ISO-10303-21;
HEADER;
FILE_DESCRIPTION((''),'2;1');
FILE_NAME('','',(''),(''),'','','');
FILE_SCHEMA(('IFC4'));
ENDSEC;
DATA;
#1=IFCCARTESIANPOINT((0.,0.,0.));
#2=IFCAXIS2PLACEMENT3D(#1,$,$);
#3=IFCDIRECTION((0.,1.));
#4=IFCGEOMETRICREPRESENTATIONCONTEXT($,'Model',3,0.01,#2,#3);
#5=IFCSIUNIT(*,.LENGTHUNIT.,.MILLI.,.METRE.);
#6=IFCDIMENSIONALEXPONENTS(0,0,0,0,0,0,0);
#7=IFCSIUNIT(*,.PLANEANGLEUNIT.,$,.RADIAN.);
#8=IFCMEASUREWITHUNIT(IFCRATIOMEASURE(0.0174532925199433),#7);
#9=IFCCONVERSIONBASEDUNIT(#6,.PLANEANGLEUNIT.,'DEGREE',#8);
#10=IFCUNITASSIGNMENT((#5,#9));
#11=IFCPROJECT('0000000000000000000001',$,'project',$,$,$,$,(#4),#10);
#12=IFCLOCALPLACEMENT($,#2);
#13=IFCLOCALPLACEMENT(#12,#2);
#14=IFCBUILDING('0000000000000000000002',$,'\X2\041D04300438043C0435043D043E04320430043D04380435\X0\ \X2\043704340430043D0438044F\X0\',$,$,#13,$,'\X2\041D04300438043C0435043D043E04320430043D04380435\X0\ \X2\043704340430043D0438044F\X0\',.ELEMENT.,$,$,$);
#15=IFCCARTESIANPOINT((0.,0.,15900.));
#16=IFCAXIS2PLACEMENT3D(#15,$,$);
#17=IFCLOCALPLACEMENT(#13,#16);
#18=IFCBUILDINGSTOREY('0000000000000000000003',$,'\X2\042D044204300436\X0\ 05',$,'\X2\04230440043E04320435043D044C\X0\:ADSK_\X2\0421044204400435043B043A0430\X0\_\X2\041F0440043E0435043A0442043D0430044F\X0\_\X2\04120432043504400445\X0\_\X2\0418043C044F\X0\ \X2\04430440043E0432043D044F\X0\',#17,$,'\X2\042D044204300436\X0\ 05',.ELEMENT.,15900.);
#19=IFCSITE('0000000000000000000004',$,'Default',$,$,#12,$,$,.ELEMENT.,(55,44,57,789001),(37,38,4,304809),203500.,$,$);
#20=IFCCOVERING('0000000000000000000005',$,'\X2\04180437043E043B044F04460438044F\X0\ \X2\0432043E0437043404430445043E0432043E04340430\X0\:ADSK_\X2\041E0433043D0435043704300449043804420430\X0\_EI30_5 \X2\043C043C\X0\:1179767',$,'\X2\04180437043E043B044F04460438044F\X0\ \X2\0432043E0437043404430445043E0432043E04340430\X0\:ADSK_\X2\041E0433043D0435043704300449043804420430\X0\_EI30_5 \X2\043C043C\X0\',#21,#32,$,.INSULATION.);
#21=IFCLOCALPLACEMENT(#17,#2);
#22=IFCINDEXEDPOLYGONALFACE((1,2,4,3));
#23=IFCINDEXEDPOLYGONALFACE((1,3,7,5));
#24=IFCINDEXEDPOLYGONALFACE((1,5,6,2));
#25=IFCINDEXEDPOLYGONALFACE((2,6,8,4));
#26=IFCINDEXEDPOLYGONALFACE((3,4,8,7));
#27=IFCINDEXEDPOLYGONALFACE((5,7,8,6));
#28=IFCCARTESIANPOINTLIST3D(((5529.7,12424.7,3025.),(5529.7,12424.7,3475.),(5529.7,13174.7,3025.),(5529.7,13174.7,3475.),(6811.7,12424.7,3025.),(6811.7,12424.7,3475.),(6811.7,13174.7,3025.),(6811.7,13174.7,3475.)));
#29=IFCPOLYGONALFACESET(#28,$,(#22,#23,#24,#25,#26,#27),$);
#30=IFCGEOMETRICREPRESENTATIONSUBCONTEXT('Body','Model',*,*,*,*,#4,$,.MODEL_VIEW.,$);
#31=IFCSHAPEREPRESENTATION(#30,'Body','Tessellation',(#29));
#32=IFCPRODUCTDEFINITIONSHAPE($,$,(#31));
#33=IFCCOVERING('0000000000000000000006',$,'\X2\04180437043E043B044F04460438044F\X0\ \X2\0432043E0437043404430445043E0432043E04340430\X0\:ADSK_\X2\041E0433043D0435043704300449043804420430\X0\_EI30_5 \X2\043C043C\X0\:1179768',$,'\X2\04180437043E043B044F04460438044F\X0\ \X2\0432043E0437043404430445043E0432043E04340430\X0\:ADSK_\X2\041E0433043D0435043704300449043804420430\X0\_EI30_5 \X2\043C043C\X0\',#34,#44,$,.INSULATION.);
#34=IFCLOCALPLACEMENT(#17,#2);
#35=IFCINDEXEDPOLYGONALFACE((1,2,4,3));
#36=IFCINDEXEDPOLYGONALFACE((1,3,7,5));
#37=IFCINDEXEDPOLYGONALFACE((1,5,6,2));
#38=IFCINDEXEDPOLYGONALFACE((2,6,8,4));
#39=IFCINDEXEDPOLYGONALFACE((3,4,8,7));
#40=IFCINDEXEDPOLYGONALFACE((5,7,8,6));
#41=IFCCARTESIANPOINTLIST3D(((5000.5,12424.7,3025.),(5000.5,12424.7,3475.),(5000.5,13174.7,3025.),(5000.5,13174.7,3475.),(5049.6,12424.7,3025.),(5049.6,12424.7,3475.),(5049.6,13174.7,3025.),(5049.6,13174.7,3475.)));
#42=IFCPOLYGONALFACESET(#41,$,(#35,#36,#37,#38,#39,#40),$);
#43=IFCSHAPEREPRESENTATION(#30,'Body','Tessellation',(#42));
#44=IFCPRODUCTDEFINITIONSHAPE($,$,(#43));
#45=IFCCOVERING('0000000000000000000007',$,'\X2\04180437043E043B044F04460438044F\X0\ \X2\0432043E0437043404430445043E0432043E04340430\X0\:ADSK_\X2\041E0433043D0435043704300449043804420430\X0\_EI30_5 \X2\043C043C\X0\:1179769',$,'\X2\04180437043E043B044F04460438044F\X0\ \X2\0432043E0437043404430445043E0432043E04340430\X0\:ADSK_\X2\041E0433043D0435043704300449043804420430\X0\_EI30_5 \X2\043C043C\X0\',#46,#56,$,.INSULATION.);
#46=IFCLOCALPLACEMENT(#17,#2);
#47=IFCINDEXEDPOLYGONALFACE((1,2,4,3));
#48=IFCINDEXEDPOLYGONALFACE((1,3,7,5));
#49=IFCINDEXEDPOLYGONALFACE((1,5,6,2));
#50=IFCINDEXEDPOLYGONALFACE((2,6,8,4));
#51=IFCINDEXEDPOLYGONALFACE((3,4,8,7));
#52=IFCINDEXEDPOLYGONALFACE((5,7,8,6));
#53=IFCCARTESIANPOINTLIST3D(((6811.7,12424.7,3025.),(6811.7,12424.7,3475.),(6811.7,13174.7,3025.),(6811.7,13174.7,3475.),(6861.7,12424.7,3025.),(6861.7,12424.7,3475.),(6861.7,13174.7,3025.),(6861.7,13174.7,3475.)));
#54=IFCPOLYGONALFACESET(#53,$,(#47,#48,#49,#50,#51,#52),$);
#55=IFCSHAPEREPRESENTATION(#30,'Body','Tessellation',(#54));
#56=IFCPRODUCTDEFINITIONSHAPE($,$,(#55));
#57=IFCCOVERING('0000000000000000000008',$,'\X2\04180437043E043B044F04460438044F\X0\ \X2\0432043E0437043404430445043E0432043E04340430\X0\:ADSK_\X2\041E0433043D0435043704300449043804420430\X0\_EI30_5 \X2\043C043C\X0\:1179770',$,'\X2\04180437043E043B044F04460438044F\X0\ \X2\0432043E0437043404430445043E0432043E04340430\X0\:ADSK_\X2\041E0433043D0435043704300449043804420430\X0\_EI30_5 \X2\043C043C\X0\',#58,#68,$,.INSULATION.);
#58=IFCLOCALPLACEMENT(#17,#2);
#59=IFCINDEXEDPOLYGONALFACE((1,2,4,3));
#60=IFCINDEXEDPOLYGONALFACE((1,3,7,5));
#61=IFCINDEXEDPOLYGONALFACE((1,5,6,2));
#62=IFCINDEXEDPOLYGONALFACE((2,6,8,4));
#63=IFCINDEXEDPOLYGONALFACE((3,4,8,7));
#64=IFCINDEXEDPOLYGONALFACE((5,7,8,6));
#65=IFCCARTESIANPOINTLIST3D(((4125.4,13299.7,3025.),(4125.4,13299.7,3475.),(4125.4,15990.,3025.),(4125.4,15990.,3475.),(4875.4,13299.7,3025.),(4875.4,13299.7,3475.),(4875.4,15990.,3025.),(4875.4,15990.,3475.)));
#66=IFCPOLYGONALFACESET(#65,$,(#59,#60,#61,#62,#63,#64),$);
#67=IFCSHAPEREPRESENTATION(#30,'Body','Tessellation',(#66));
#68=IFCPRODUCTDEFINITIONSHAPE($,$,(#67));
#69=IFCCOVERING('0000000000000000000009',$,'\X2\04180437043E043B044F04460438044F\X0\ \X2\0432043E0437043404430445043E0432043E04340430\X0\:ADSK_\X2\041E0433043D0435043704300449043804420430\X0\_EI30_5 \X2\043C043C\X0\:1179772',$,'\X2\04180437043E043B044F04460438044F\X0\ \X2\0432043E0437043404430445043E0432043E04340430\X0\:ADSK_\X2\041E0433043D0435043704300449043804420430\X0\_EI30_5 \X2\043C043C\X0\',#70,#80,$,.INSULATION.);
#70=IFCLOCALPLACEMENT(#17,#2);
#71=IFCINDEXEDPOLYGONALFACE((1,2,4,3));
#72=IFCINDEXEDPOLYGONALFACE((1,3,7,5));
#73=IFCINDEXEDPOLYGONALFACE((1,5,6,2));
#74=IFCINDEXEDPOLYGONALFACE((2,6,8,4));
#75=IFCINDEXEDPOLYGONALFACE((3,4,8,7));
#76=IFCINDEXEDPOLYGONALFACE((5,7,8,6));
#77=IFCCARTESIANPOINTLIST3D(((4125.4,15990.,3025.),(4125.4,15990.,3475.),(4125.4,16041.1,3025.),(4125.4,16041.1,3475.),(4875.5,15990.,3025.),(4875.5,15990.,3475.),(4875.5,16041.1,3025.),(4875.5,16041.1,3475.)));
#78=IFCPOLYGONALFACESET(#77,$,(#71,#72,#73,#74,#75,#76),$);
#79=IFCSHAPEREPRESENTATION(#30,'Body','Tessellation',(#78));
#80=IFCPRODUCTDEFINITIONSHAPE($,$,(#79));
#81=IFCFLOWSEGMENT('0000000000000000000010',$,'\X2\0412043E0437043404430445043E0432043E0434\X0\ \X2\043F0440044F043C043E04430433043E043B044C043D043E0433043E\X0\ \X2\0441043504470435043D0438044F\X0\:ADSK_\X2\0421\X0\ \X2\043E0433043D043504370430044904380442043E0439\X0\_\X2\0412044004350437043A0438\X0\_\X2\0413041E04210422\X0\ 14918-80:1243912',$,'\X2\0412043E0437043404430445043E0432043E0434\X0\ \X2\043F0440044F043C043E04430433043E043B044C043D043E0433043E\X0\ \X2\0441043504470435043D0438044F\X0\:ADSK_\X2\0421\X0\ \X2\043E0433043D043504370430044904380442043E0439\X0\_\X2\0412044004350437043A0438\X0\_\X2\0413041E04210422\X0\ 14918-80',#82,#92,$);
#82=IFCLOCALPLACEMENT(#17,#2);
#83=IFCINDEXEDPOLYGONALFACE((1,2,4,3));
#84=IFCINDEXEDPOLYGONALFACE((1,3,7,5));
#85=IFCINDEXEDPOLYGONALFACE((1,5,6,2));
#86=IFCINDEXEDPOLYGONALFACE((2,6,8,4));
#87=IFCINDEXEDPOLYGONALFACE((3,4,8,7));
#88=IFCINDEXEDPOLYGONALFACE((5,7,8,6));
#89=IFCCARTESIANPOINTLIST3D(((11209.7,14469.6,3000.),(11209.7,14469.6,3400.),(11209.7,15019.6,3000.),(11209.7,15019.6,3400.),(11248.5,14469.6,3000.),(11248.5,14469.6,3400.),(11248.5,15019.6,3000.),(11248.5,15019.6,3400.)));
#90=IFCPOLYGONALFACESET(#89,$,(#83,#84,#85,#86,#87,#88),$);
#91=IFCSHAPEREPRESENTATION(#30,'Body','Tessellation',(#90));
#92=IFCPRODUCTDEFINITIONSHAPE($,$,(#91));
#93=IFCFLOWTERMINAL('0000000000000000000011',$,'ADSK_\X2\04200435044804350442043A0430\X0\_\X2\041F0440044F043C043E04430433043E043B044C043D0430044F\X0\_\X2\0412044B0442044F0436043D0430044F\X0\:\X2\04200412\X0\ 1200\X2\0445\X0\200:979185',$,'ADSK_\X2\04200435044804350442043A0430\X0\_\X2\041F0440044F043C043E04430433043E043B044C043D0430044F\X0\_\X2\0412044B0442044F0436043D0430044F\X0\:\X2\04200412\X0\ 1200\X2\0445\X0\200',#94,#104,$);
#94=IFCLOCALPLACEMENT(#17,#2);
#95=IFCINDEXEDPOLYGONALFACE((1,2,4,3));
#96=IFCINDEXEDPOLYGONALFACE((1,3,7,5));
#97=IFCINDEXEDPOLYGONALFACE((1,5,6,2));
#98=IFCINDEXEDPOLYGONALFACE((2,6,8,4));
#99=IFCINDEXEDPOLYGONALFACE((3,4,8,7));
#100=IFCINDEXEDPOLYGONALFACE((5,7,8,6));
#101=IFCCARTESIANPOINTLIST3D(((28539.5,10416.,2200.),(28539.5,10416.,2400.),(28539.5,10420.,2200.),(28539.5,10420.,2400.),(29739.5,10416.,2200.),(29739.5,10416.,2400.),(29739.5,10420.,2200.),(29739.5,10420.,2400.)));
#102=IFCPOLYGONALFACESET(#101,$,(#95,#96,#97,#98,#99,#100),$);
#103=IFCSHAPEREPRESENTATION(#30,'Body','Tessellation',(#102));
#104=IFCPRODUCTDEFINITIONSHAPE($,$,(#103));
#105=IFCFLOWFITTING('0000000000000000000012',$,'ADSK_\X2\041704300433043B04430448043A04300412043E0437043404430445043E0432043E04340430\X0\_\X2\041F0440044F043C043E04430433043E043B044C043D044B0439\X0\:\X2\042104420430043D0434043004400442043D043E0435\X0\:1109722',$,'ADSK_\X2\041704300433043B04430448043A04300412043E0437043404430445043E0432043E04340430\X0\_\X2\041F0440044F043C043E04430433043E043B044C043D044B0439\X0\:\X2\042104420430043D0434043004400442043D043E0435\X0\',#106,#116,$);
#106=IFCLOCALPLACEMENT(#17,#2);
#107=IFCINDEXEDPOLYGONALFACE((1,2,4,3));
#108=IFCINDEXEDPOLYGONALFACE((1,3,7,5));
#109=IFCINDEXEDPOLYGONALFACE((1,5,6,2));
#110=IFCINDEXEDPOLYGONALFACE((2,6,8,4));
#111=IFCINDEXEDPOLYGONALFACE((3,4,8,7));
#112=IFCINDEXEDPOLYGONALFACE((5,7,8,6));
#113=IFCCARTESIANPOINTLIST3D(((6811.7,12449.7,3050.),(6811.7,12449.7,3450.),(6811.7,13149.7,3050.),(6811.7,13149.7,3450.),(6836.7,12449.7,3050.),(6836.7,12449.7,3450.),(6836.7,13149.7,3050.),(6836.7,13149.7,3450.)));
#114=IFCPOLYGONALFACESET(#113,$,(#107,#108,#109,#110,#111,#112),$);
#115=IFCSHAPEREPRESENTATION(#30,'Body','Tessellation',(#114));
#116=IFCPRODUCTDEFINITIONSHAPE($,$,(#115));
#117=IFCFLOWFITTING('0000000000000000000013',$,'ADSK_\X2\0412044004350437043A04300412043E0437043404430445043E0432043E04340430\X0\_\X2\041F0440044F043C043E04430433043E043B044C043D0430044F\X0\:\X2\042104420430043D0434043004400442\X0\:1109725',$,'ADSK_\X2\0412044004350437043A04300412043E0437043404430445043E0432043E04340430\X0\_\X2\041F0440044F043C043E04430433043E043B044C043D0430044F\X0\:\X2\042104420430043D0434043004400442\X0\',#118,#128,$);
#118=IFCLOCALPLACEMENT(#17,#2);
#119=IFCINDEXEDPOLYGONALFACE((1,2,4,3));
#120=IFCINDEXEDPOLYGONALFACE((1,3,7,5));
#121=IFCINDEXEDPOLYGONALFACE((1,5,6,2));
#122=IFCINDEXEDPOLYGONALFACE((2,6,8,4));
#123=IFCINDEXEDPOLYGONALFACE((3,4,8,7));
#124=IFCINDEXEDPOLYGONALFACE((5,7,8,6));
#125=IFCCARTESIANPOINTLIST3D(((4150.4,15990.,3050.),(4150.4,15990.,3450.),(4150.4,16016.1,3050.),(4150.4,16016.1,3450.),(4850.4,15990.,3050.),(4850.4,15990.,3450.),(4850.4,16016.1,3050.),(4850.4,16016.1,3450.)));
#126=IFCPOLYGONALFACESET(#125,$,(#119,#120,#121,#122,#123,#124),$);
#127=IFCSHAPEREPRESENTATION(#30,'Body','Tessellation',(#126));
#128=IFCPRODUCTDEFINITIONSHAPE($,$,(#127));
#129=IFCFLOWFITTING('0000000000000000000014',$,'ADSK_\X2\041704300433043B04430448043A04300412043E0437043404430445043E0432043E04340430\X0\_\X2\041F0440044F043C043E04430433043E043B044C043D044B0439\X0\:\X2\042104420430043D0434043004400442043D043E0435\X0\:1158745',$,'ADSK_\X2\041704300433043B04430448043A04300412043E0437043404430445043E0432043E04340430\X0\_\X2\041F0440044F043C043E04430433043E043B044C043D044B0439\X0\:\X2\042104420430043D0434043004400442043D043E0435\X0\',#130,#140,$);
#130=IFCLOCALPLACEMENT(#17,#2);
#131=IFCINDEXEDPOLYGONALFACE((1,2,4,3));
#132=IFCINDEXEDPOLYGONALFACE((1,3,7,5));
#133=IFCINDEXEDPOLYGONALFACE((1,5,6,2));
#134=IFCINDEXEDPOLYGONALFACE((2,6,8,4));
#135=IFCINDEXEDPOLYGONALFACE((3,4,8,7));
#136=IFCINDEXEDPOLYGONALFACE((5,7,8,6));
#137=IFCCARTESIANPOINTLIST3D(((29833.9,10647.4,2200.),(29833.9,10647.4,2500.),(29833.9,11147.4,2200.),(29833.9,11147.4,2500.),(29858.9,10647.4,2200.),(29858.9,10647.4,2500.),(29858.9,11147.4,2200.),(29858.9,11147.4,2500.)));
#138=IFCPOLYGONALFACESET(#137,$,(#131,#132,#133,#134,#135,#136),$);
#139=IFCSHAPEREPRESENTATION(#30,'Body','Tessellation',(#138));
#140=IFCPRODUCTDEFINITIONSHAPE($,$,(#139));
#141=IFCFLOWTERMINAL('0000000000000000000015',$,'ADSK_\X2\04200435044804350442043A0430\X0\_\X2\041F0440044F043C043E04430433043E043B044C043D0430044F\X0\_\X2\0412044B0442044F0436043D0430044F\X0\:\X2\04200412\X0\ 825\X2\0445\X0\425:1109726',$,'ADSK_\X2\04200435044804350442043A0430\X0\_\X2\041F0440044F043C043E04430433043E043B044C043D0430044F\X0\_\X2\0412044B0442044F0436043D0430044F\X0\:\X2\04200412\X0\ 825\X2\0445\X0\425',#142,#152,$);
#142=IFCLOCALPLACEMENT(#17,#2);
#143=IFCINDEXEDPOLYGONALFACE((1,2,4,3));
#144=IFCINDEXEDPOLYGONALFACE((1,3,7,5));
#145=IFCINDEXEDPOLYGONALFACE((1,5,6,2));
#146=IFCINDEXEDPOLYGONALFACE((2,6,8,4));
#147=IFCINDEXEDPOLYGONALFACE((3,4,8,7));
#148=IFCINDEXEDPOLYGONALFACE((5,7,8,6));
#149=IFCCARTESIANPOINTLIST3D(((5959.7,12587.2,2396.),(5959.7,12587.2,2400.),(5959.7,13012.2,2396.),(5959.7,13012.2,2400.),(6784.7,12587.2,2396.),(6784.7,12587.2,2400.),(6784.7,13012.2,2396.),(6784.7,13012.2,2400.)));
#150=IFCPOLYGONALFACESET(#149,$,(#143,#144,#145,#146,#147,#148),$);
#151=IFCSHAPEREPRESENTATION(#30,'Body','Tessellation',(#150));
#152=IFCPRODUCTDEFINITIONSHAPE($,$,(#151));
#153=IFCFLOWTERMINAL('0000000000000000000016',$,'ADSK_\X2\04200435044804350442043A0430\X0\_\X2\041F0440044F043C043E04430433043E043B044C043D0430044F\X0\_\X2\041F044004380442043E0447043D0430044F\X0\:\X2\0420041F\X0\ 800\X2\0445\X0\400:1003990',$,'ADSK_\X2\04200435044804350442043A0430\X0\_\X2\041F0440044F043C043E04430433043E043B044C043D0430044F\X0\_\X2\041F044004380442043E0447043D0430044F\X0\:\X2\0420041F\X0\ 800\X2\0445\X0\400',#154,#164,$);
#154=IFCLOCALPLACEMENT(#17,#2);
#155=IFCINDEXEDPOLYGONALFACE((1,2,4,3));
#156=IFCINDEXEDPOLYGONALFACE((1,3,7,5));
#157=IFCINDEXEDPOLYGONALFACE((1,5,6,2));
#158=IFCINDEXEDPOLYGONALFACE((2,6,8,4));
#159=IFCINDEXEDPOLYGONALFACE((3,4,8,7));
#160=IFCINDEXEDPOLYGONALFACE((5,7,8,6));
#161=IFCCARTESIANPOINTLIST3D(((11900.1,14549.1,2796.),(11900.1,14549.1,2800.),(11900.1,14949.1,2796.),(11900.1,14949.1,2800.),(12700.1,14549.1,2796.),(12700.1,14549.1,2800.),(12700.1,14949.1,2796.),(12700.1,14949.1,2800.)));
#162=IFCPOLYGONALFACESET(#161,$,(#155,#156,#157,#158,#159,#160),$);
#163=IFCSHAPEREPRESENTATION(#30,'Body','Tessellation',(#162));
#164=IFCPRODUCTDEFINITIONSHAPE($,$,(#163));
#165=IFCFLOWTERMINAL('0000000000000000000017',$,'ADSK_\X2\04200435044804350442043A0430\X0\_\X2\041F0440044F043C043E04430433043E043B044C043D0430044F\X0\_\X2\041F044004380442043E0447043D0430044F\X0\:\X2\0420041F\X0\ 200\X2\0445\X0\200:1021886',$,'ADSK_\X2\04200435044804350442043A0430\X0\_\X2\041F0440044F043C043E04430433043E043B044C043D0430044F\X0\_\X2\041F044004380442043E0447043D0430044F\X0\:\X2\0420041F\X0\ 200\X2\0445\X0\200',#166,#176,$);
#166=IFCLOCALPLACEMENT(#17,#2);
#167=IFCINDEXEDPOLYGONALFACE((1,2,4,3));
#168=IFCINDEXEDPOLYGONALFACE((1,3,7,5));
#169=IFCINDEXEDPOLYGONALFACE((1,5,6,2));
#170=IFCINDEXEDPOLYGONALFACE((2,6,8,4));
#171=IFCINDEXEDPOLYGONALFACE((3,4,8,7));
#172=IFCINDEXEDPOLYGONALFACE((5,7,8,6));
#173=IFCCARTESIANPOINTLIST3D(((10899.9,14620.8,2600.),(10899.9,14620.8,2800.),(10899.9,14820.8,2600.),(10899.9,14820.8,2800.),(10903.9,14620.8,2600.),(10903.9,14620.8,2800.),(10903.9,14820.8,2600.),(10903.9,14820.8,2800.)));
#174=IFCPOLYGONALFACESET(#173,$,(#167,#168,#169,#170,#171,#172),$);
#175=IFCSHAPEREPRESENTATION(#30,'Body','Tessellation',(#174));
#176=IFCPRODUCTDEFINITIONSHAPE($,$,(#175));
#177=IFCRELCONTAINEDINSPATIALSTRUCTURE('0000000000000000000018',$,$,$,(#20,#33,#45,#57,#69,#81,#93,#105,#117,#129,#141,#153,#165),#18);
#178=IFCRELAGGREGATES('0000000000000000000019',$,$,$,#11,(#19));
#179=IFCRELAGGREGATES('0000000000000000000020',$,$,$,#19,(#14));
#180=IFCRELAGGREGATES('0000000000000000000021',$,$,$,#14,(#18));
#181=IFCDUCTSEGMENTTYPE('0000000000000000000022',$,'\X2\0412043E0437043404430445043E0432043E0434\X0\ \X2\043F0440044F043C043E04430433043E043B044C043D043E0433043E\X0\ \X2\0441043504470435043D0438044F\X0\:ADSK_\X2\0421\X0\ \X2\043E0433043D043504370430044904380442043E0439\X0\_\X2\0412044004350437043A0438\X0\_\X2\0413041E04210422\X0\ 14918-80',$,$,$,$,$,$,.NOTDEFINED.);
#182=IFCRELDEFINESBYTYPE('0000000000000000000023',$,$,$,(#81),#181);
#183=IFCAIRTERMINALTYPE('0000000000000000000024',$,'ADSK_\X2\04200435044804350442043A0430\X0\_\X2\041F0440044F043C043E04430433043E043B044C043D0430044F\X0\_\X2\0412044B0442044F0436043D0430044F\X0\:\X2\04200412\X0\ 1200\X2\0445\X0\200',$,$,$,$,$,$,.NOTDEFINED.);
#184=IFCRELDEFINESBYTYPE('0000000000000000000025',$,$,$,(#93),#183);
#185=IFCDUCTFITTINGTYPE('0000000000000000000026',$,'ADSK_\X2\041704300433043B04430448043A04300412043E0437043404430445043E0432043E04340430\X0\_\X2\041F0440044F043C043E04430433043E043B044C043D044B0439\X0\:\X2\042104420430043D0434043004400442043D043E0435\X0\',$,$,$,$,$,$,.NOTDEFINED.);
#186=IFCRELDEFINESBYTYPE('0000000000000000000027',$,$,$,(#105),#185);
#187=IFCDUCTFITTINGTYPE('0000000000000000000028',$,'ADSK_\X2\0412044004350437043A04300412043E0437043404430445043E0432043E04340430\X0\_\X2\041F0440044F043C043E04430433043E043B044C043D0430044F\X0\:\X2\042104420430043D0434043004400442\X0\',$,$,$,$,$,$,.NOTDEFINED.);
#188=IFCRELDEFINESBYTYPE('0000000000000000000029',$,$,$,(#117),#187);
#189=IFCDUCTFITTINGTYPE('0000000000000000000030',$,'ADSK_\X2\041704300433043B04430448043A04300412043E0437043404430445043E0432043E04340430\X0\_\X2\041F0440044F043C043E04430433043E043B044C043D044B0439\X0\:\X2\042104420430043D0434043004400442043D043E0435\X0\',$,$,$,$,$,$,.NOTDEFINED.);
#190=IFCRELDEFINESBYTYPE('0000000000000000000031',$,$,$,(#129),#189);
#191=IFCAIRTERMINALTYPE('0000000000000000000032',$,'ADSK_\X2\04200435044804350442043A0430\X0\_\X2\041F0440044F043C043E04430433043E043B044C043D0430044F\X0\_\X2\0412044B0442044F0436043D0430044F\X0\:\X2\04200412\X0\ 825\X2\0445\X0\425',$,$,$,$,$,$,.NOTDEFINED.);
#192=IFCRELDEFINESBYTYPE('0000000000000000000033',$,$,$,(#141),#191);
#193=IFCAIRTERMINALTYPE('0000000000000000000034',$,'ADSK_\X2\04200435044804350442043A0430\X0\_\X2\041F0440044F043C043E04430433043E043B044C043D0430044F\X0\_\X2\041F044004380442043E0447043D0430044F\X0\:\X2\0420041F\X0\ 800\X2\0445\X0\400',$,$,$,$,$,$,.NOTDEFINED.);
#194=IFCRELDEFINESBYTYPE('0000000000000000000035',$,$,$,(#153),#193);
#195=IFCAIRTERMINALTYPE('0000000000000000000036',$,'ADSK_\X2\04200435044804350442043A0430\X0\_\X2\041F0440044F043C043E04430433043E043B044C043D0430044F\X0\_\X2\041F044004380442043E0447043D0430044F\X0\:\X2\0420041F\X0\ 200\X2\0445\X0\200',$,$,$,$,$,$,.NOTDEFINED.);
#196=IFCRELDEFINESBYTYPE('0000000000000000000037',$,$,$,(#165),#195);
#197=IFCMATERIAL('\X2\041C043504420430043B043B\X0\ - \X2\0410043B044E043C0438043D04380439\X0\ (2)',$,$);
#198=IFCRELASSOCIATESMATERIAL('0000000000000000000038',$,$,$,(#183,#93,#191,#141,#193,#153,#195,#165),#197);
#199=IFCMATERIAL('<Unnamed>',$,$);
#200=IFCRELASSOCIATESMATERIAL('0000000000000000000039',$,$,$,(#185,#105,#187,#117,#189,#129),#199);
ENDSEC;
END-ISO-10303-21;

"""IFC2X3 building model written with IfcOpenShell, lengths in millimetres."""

from ifc_helpers import new_model, entity, si_unit, converted_unit, direction, frame, origin, origin_2d_with_axis, place, context, subcontext, project, spatial, rectangle, extrude, source, transform, mapped, material, type_object, type_shapes, element, save


model = new_model("IFC2X3")

# Units and contexts
model_context = context("Model", 3, precision=0.01, world=origin(), true_north=direction((0.0, 1.0)))
body_context = subcontext(model_context, "Body", "Model", "MODEL_VIEW")
ifc_project = project(units=[si_unit("LENGTHUNIT", "METRE", prefix="MILLI"), converted_unit("PLANEANGLEUNIT", "DEGREE", entity("IfcRatioMeasure", 0.0174532925199433), si_unit("PLANEANGLEUNIT", "RADIAN"), dimensions=[0, 0, 0, 0, 0, 0, 0])], contexts=[model_context])

# Site, building, storey
site_placement = place(None, origin())
site = spatial("IfcSite", under=ifc_project, at=site_placement, Name="Default", CompositionType="ELEMENT", RefLatitude=(55, 44, 57, 789001), RefLongitude=(37, 38, 4, 304809), RefElevation=203500.0)
building_placement = place(site_placement, origin())
building = spatial("IfcBuilding", under=site, at=building_placement, Name="Наименование здания", LongName="Наименование здания", CompositionType="ELEMENT")
storey_placement = place(building_placement, frame((0.0, 0.0, 15900.0)))
storey = spatial("IfcBuildingStorey", under=building, at=storey_placement, Name="Этаж 05", ObjectType="Уровень:ADSK_Стрелка_Проектная_Вверх_Имя уровня", LongName="Этаж 05", CompositionType="ELEMENT", Elevation=15900.0)

# Coverings
covering_1_placement = place(storey_placement, frame((5529.6, 12424.7, 3025.0)))
element("IfcCovering", 1, at=covering_1_placement, inside=storey, Name="Изоляция воздуховода:ADSK_Огнезащита_EI30_5 мм:1179767", ObjectType="Изоляция воздуховода:ADSK_Огнезащита_EI30_5 мм", PredefinedType="INSULATION", context=body_context, shape_type="SweptSolid", body=[
    extrude(rectangle(XDim=1282.1, YDim=750.0, at=origin_2d_with_axis()), frame((641.0, 375.0, 0.0)), (0.0, 0.0, 1.0), 450.0),
])
covering_2_placement = place(storey_placement, frame((5000.4, 12424.7, 3025.0)))
element("IfcCovering", 2, at=covering_2_placement, inside=storey, Name="Изоляция воздуховода:ADSK_Огнезащита_EI30_5 мм:1179768", ObjectType="Изоляция воздуховода:ADSK_Огнезащита_EI30_5 мм", PredefinedType="INSULATION", context=body_context, shape_type="SweptSolid", body=[
    extrude(rectangle(XDim=49.2, YDim=750.0, at=origin_2d_with_axis()), frame((24.6, 375.0, 0.0)), (0.0, 0.0, 1.0), 450.0),
])
covering_3_placement = place(storey_placement, frame((6811.7, 12424.7, 3025.0)))
element("IfcCovering", 3, at=covering_3_placement, inside=storey, Name="Изоляция воздуховода:ADSK_Огнезащита_EI30_5 мм:1179769", ObjectType="Изоляция воздуховода:ADSK_Огнезащита_EI30_5 мм", PredefinedType="INSULATION", context=body_context, shape_type="SweptSolid", body=[
    extrude(rectangle(XDim=50.0, YDim=750.0, at=origin_2d_with_axis()), frame((25.0, 375.0, 0.0), z_axis=(0.0, 0.0, 1.0), x_axis=(-1.0, 0.0, 0.0)), (0.0, 0.0, 1.0), 450.0),
])
covering_4_placement = place(storey_placement, frame((4125.4, 13299.7, 3025.0)))
element("IfcCovering", 4, at=covering_4_placement, inside=storey, Name="Изоляция воздуховода:ADSK_Огнезащита_EI30_5 мм:1179770", ObjectType="Изоляция воздуховода:ADSK_Огнезащита_EI30_5 мм", PredefinedType="INSULATION", context=body_context, shape_type="SweptSolid", body=[
    extrude(rectangle(XDim=2690.3, YDim=750.0, at=origin_2d_with_axis()), frame((375.0, 1345.2, 0.0), z_axis=(0.0, 0.0, 1.0), x_axis=(0.0, 1.0, 0.0)), (0.0, 0.0, 1.0), 450.0),
])
covering_5_placement = place(storey_placement, frame((4125.4, 15990.0, 3025.0)))
element("IfcCovering", 5, at=covering_5_placement, inside=storey, Name="Изоляция воздуховода:ADSK_Огнезащита_EI30_5 мм:1179772", ObjectType="Изоляция воздуховода:ADSK_Огнезащита_EI30_5 мм", PredefinedType="INSULATION", context=body_context, shape_type="SweptSolid", body=[
    extrude(rectangle(XDim=750.0, YDim=51.1, at=origin_2d_with_axis()), frame((375.0, 25.6, 0.0)), (0.0, 0.0, 1.0), 450.0),
])

# Flow segment
duct_segment_type = type_object("IfcDuctSegmentType", Name="Воздуховод прямоугольного сечения:ADSK_С огнезащитой_Врезки_ГОСТ 14918-80", PredefinedType="NOTDEFINED")
flow_segment_placement = place(storey_placement, frame((11209.7, 14469.6, 3000.0)))
element("IfcFlowSegment", 6, at=flow_segment_placement, inside=storey, type_object=duct_segment_type, Name="Воздуховод прямоугольного сечения:ADSK_С огнезащитой_Врезки_ГОСТ 14918-80:1243912", ObjectType="Воздуховод прямоугольного сечения:ADSK_С огнезащитой_Врезки_ГОСТ 14918-80", context=body_context, shape_type="SweptSolid", body=[
    extrude(rectangle(XDim=38.8, YDim=550.0, at=origin_2d_with_axis()), frame((19.4, 275.0, 0.0)), (0.0, 0.0, 1.0), 400.0),
])

# Flow terminal
ifc_material_1 = material(Name="Металл - Алюминий (2)")
air_terminal_type_1 = type_object("IfcAirTerminalType", Name="ADSK_Решетка_Прямоугольная_Вытяжная:РВ 1200х200", PredefinedType="NOTDEFINED", material=ifc_material_1)
shared_shape_1 = source(origin(), body_context, "Body", "SweptSolid", [
    extrude(rectangle(XDim=4.0, YDim=1200.0, at=origin_2d_with_axis()), frame((0.0, -2.0, -100.0), z_axis=(0.0, 0.0, 1.0), x_axis=(0.0, 1.0, 0.0)), (0.0, 0.0, 1.0), 200.0),
])
type_shapes(air_terminal_type_1, [shared_shape_1])
flow_terminal_1_placement = place(storey_placement, frame((29139.5, 10420.0, 2300.0)))
element("IfcFlowTerminal", 7, at=flow_terminal_1_placement, inside=storey, type_object=air_terminal_type_1, material=ifc_material_1, Name="ADSK_Решетка_Прямоугольная_Вытяжная:РВ 1200х200:979185", ObjectType="ADSK_Решетка_Прямоугольная_Вытяжная:РВ 1200х200", context=body_context, shape_type="MappedRepresentation", body=[
    mapped(shared_shape_1, transform((0.0, 0.0, 0.0), scale=1.0)),
])

# Flow fittings
ifc_material_2 = material(Name="<Unnamed>")
duct_fitting_type_1 = type_object("IfcDuctFittingType", Name="ADSK_ЗаглушкаВоздуховода_Прямоугольный:Стандартное", PredefinedType="NOTDEFINED", material=ifc_material_2)
shared_shape_2 = source(origin(), body_context, "Body", "SweptSolid", [
    extrude(rectangle(XDim=25.0, YDim=700.0, at=origin_2d_with_axis()), frame((12.5, 0.0, -200.0)), (0.0, 0.0, 1.0), 400.0),
])
type_shapes(duct_fitting_type_1, [shared_shape_2])
flow_fitting_1_placement = place(storey_placement, frame((6811.7, 12799.7, 3250.0)))
element("IfcFlowFitting", 8, at=flow_fitting_1_placement, inside=storey, type_object=duct_fitting_type_1, material=ifc_material_2, Name="ADSK_ЗаглушкаВоздуховода_Прямоугольный:Стандартное:1109722", ObjectType="ADSK_ЗаглушкаВоздуховода_Прямоугольный:Стандартное", context=body_context, shape_type="MappedRepresentation", body=[
    mapped(shared_shape_2, transform((0.0, 0.0, 0.0), scale=1.0)),
])
duct_fitting_type_2 = type_object("IfcDuctFittingType", Name="ADSK_ВрезкаВоздуховода_Прямоугольная:Стандарт", PredefinedType="NOTDEFINED", material=ifc_material_2)
shared_shape_3 = source(origin(), body_context, "Body", "SweptSolid", [
    extrude(rectangle(XDim=26.1, YDim=400.0, at=origin_2d_with_axis()), frame((7.0, 0.0, -350.0)), (0.0, 0.0, 1.0), 700.0),
])
type_shapes(duct_fitting_type_2, [shared_shape_3])
flow_fitting_2_placement = place(storey_placement, frame((4500.4, 16010.0, 3250.0), z_axis=(-1.0, 0.0, 0.0), x_axis=(0.0, -1.0, 0.0)))
element("IfcFlowFitting", 9, at=flow_fitting_2_placement, inside=storey, type_object=duct_fitting_type_2, material=ifc_material_2, Name="ADSK_ВрезкаВоздуховода_Прямоугольная:Стандарт:1109725", ObjectType="ADSK_ВрезкаВоздуховода_Прямоугольная:Стандарт", context=body_context, shape_type="MappedRepresentation", body=[
    mapped(shared_shape_3, transform((0.0, 0.0, 0.0), scale=1.0)),
])
duct_fitting_type_3 = type_object("IfcDuctFittingType", Name="ADSK_ЗаглушкаВоздуховода_Прямоугольный:Стандартное", PredefinedType="NOTDEFINED", material=ifc_material_2)
shared_shape_4 = source(origin(), body_context, "Body", "SweptSolid", [
    extrude(rectangle(XDim=25.0, YDim=500.0, at=origin_2d_with_axis()), frame((12.5, 0.0, -150.0)), (0.0, 0.0, 1.0), 300.0),
])
type_shapes(duct_fitting_type_3, [shared_shape_4])
flow_fitting_3_placement = place(storey_placement, frame((29833.9, 10897.4, 2350.0)))
element("IfcFlowFitting", 10, at=flow_fitting_3_placement, inside=storey, type_object=duct_fitting_type_3, material=ifc_material_2, Name="ADSK_ЗаглушкаВоздуховода_Прямоугольный:Стандартное:1158745", ObjectType="ADSK_ЗаглушкаВоздуховода_Прямоугольный:Стандартное", context=body_context, shape_type="MappedRepresentation", body=[
    mapped(shared_shape_4, transform((0.0, 0.0, 0.0), scale=1.0)),
])

# Flow terminals
air_terminal_type_2 = type_object("IfcAirTerminalType", Name="ADSK_Решетка_Прямоугольная_Вытяжная:РВ 825х425", PredefinedType="NOTDEFINED", material=ifc_material_1)
shared_shape_5 = source(origin(), body_context, "Body", "SweptSolid", [
    extrude(rectangle(XDim=4.0, YDim=825.0, at=origin_2d_with_axis()), frame((0.0, -2.0, -212.5), z_axis=(0.0, 0.0, 1.0), x_axis=(0.0, 1.0, 0.0)), (0.0, 0.0, 1.0), 425.0),
])
type_shapes(air_terminal_type_2, [shared_shape_5])
flow_terminal_2_placement = place(storey_placement, frame((6372.2, 12799.7, 2400.0), z_axis=(0.0, 1.0, 0.0), x_axis=(-1.0, 0.0, 0.0)))
element("IfcFlowTerminal", 11, at=flow_terminal_2_placement, inside=storey, type_object=air_terminal_type_2, material=ifc_material_1, Name="ADSK_Решетка_Прямоугольная_Вытяжная:РВ 825х425:1109726", ObjectType="ADSK_Решетка_Прямоугольная_Вытяжная:РВ 825х425", context=body_context, shape_type="MappedRepresentation", body=[
    mapped(shared_shape_5, transform((0.0, 0.0, 0.0), scale=1.0)),
])
air_terminal_type_3 = type_object("IfcAirTerminalType", Name="ADSK_Решетка_Прямоугольная_Приточная:РП 800х400", PredefinedType="NOTDEFINED", material=ifc_material_1)
shared_shape_6 = source(origin(), body_context, "Body", "SweptSolid", [
    extrude(rectangle(XDim=4.0, YDim=800.0, at=origin_2d_with_axis()), frame((0.0, -2.0, -200.0), z_axis=(0.0, 0.0, 1.0), x_axis=(0.0, 1.0, 0.0)), (0.0, 0.0, 1.0), 400.0),
])
type_shapes(air_terminal_type_3, [shared_shape_6])
flow_terminal_3_placement = place(storey_placement, frame((12300.1, 14749.1, 2800.0), z_axis=(0.0, 1.0, 0.0), x_axis=(-1.0, 0.0, 0.0)))
element("IfcFlowTerminal", 12, at=flow_terminal_3_placement, inside=storey, type_object=air_terminal_type_3, material=ifc_material_1, Name="ADSK_Решетка_Прямоугольная_Приточная:РП 800х400:1003990", ObjectType="ADSK_Решетка_Прямоугольная_Приточная:РП 800х400", context=body_context, shape_type="MappedRepresentation", body=[
    mapped(shared_shape_6, transform((0.0, 0.0, 0.0), scale=1.0)),
])
air_terminal_type_4 = type_object("IfcAirTerminalType", Name="ADSK_Решетка_Прямоугольная_Приточная:РП 200х200", PredefinedType="NOTDEFINED", material=ifc_material_1)
shared_shape_7 = source(origin(), body_context, "Body", "SweptSolid", [
    extrude(rectangle(XDim=4.0, YDim=200.0, at=origin_2d_with_axis()), frame((0.0, -2.0, -100.0), z_axis=(0.0, 0.0, 1.0), x_axis=(0.0, 1.0, 0.0)), (0.0, 0.0, 1.0), 200.0),
])
type_shapes(air_terminal_type_4, [shared_shape_7])
flow_terminal_4_placement = place(storey_placement, frame((10899.9, 14720.8, 2700.0), z_axis=(0.0, 0.0, 1.0), x_axis=(0.0, 1.0, 0.0)))
element("IfcFlowTerminal", 13, at=flow_terminal_4_placement, inside=storey, type_object=air_terminal_type_4, material=ifc_material_1, Name="ADSK_Решетка_Прямоугольная_Приточная:РП 200х200:1021886", ObjectType="ADSK_Решетка_Прямоугольная_Приточная:РП 200х200", context=body_context, shape_type="MappedRepresentation", body=[
    mapped(shared_shape_7, transform((0.0, 0.0, 0.0), scale=1.0)),
])

save(model, "model.ifc")
